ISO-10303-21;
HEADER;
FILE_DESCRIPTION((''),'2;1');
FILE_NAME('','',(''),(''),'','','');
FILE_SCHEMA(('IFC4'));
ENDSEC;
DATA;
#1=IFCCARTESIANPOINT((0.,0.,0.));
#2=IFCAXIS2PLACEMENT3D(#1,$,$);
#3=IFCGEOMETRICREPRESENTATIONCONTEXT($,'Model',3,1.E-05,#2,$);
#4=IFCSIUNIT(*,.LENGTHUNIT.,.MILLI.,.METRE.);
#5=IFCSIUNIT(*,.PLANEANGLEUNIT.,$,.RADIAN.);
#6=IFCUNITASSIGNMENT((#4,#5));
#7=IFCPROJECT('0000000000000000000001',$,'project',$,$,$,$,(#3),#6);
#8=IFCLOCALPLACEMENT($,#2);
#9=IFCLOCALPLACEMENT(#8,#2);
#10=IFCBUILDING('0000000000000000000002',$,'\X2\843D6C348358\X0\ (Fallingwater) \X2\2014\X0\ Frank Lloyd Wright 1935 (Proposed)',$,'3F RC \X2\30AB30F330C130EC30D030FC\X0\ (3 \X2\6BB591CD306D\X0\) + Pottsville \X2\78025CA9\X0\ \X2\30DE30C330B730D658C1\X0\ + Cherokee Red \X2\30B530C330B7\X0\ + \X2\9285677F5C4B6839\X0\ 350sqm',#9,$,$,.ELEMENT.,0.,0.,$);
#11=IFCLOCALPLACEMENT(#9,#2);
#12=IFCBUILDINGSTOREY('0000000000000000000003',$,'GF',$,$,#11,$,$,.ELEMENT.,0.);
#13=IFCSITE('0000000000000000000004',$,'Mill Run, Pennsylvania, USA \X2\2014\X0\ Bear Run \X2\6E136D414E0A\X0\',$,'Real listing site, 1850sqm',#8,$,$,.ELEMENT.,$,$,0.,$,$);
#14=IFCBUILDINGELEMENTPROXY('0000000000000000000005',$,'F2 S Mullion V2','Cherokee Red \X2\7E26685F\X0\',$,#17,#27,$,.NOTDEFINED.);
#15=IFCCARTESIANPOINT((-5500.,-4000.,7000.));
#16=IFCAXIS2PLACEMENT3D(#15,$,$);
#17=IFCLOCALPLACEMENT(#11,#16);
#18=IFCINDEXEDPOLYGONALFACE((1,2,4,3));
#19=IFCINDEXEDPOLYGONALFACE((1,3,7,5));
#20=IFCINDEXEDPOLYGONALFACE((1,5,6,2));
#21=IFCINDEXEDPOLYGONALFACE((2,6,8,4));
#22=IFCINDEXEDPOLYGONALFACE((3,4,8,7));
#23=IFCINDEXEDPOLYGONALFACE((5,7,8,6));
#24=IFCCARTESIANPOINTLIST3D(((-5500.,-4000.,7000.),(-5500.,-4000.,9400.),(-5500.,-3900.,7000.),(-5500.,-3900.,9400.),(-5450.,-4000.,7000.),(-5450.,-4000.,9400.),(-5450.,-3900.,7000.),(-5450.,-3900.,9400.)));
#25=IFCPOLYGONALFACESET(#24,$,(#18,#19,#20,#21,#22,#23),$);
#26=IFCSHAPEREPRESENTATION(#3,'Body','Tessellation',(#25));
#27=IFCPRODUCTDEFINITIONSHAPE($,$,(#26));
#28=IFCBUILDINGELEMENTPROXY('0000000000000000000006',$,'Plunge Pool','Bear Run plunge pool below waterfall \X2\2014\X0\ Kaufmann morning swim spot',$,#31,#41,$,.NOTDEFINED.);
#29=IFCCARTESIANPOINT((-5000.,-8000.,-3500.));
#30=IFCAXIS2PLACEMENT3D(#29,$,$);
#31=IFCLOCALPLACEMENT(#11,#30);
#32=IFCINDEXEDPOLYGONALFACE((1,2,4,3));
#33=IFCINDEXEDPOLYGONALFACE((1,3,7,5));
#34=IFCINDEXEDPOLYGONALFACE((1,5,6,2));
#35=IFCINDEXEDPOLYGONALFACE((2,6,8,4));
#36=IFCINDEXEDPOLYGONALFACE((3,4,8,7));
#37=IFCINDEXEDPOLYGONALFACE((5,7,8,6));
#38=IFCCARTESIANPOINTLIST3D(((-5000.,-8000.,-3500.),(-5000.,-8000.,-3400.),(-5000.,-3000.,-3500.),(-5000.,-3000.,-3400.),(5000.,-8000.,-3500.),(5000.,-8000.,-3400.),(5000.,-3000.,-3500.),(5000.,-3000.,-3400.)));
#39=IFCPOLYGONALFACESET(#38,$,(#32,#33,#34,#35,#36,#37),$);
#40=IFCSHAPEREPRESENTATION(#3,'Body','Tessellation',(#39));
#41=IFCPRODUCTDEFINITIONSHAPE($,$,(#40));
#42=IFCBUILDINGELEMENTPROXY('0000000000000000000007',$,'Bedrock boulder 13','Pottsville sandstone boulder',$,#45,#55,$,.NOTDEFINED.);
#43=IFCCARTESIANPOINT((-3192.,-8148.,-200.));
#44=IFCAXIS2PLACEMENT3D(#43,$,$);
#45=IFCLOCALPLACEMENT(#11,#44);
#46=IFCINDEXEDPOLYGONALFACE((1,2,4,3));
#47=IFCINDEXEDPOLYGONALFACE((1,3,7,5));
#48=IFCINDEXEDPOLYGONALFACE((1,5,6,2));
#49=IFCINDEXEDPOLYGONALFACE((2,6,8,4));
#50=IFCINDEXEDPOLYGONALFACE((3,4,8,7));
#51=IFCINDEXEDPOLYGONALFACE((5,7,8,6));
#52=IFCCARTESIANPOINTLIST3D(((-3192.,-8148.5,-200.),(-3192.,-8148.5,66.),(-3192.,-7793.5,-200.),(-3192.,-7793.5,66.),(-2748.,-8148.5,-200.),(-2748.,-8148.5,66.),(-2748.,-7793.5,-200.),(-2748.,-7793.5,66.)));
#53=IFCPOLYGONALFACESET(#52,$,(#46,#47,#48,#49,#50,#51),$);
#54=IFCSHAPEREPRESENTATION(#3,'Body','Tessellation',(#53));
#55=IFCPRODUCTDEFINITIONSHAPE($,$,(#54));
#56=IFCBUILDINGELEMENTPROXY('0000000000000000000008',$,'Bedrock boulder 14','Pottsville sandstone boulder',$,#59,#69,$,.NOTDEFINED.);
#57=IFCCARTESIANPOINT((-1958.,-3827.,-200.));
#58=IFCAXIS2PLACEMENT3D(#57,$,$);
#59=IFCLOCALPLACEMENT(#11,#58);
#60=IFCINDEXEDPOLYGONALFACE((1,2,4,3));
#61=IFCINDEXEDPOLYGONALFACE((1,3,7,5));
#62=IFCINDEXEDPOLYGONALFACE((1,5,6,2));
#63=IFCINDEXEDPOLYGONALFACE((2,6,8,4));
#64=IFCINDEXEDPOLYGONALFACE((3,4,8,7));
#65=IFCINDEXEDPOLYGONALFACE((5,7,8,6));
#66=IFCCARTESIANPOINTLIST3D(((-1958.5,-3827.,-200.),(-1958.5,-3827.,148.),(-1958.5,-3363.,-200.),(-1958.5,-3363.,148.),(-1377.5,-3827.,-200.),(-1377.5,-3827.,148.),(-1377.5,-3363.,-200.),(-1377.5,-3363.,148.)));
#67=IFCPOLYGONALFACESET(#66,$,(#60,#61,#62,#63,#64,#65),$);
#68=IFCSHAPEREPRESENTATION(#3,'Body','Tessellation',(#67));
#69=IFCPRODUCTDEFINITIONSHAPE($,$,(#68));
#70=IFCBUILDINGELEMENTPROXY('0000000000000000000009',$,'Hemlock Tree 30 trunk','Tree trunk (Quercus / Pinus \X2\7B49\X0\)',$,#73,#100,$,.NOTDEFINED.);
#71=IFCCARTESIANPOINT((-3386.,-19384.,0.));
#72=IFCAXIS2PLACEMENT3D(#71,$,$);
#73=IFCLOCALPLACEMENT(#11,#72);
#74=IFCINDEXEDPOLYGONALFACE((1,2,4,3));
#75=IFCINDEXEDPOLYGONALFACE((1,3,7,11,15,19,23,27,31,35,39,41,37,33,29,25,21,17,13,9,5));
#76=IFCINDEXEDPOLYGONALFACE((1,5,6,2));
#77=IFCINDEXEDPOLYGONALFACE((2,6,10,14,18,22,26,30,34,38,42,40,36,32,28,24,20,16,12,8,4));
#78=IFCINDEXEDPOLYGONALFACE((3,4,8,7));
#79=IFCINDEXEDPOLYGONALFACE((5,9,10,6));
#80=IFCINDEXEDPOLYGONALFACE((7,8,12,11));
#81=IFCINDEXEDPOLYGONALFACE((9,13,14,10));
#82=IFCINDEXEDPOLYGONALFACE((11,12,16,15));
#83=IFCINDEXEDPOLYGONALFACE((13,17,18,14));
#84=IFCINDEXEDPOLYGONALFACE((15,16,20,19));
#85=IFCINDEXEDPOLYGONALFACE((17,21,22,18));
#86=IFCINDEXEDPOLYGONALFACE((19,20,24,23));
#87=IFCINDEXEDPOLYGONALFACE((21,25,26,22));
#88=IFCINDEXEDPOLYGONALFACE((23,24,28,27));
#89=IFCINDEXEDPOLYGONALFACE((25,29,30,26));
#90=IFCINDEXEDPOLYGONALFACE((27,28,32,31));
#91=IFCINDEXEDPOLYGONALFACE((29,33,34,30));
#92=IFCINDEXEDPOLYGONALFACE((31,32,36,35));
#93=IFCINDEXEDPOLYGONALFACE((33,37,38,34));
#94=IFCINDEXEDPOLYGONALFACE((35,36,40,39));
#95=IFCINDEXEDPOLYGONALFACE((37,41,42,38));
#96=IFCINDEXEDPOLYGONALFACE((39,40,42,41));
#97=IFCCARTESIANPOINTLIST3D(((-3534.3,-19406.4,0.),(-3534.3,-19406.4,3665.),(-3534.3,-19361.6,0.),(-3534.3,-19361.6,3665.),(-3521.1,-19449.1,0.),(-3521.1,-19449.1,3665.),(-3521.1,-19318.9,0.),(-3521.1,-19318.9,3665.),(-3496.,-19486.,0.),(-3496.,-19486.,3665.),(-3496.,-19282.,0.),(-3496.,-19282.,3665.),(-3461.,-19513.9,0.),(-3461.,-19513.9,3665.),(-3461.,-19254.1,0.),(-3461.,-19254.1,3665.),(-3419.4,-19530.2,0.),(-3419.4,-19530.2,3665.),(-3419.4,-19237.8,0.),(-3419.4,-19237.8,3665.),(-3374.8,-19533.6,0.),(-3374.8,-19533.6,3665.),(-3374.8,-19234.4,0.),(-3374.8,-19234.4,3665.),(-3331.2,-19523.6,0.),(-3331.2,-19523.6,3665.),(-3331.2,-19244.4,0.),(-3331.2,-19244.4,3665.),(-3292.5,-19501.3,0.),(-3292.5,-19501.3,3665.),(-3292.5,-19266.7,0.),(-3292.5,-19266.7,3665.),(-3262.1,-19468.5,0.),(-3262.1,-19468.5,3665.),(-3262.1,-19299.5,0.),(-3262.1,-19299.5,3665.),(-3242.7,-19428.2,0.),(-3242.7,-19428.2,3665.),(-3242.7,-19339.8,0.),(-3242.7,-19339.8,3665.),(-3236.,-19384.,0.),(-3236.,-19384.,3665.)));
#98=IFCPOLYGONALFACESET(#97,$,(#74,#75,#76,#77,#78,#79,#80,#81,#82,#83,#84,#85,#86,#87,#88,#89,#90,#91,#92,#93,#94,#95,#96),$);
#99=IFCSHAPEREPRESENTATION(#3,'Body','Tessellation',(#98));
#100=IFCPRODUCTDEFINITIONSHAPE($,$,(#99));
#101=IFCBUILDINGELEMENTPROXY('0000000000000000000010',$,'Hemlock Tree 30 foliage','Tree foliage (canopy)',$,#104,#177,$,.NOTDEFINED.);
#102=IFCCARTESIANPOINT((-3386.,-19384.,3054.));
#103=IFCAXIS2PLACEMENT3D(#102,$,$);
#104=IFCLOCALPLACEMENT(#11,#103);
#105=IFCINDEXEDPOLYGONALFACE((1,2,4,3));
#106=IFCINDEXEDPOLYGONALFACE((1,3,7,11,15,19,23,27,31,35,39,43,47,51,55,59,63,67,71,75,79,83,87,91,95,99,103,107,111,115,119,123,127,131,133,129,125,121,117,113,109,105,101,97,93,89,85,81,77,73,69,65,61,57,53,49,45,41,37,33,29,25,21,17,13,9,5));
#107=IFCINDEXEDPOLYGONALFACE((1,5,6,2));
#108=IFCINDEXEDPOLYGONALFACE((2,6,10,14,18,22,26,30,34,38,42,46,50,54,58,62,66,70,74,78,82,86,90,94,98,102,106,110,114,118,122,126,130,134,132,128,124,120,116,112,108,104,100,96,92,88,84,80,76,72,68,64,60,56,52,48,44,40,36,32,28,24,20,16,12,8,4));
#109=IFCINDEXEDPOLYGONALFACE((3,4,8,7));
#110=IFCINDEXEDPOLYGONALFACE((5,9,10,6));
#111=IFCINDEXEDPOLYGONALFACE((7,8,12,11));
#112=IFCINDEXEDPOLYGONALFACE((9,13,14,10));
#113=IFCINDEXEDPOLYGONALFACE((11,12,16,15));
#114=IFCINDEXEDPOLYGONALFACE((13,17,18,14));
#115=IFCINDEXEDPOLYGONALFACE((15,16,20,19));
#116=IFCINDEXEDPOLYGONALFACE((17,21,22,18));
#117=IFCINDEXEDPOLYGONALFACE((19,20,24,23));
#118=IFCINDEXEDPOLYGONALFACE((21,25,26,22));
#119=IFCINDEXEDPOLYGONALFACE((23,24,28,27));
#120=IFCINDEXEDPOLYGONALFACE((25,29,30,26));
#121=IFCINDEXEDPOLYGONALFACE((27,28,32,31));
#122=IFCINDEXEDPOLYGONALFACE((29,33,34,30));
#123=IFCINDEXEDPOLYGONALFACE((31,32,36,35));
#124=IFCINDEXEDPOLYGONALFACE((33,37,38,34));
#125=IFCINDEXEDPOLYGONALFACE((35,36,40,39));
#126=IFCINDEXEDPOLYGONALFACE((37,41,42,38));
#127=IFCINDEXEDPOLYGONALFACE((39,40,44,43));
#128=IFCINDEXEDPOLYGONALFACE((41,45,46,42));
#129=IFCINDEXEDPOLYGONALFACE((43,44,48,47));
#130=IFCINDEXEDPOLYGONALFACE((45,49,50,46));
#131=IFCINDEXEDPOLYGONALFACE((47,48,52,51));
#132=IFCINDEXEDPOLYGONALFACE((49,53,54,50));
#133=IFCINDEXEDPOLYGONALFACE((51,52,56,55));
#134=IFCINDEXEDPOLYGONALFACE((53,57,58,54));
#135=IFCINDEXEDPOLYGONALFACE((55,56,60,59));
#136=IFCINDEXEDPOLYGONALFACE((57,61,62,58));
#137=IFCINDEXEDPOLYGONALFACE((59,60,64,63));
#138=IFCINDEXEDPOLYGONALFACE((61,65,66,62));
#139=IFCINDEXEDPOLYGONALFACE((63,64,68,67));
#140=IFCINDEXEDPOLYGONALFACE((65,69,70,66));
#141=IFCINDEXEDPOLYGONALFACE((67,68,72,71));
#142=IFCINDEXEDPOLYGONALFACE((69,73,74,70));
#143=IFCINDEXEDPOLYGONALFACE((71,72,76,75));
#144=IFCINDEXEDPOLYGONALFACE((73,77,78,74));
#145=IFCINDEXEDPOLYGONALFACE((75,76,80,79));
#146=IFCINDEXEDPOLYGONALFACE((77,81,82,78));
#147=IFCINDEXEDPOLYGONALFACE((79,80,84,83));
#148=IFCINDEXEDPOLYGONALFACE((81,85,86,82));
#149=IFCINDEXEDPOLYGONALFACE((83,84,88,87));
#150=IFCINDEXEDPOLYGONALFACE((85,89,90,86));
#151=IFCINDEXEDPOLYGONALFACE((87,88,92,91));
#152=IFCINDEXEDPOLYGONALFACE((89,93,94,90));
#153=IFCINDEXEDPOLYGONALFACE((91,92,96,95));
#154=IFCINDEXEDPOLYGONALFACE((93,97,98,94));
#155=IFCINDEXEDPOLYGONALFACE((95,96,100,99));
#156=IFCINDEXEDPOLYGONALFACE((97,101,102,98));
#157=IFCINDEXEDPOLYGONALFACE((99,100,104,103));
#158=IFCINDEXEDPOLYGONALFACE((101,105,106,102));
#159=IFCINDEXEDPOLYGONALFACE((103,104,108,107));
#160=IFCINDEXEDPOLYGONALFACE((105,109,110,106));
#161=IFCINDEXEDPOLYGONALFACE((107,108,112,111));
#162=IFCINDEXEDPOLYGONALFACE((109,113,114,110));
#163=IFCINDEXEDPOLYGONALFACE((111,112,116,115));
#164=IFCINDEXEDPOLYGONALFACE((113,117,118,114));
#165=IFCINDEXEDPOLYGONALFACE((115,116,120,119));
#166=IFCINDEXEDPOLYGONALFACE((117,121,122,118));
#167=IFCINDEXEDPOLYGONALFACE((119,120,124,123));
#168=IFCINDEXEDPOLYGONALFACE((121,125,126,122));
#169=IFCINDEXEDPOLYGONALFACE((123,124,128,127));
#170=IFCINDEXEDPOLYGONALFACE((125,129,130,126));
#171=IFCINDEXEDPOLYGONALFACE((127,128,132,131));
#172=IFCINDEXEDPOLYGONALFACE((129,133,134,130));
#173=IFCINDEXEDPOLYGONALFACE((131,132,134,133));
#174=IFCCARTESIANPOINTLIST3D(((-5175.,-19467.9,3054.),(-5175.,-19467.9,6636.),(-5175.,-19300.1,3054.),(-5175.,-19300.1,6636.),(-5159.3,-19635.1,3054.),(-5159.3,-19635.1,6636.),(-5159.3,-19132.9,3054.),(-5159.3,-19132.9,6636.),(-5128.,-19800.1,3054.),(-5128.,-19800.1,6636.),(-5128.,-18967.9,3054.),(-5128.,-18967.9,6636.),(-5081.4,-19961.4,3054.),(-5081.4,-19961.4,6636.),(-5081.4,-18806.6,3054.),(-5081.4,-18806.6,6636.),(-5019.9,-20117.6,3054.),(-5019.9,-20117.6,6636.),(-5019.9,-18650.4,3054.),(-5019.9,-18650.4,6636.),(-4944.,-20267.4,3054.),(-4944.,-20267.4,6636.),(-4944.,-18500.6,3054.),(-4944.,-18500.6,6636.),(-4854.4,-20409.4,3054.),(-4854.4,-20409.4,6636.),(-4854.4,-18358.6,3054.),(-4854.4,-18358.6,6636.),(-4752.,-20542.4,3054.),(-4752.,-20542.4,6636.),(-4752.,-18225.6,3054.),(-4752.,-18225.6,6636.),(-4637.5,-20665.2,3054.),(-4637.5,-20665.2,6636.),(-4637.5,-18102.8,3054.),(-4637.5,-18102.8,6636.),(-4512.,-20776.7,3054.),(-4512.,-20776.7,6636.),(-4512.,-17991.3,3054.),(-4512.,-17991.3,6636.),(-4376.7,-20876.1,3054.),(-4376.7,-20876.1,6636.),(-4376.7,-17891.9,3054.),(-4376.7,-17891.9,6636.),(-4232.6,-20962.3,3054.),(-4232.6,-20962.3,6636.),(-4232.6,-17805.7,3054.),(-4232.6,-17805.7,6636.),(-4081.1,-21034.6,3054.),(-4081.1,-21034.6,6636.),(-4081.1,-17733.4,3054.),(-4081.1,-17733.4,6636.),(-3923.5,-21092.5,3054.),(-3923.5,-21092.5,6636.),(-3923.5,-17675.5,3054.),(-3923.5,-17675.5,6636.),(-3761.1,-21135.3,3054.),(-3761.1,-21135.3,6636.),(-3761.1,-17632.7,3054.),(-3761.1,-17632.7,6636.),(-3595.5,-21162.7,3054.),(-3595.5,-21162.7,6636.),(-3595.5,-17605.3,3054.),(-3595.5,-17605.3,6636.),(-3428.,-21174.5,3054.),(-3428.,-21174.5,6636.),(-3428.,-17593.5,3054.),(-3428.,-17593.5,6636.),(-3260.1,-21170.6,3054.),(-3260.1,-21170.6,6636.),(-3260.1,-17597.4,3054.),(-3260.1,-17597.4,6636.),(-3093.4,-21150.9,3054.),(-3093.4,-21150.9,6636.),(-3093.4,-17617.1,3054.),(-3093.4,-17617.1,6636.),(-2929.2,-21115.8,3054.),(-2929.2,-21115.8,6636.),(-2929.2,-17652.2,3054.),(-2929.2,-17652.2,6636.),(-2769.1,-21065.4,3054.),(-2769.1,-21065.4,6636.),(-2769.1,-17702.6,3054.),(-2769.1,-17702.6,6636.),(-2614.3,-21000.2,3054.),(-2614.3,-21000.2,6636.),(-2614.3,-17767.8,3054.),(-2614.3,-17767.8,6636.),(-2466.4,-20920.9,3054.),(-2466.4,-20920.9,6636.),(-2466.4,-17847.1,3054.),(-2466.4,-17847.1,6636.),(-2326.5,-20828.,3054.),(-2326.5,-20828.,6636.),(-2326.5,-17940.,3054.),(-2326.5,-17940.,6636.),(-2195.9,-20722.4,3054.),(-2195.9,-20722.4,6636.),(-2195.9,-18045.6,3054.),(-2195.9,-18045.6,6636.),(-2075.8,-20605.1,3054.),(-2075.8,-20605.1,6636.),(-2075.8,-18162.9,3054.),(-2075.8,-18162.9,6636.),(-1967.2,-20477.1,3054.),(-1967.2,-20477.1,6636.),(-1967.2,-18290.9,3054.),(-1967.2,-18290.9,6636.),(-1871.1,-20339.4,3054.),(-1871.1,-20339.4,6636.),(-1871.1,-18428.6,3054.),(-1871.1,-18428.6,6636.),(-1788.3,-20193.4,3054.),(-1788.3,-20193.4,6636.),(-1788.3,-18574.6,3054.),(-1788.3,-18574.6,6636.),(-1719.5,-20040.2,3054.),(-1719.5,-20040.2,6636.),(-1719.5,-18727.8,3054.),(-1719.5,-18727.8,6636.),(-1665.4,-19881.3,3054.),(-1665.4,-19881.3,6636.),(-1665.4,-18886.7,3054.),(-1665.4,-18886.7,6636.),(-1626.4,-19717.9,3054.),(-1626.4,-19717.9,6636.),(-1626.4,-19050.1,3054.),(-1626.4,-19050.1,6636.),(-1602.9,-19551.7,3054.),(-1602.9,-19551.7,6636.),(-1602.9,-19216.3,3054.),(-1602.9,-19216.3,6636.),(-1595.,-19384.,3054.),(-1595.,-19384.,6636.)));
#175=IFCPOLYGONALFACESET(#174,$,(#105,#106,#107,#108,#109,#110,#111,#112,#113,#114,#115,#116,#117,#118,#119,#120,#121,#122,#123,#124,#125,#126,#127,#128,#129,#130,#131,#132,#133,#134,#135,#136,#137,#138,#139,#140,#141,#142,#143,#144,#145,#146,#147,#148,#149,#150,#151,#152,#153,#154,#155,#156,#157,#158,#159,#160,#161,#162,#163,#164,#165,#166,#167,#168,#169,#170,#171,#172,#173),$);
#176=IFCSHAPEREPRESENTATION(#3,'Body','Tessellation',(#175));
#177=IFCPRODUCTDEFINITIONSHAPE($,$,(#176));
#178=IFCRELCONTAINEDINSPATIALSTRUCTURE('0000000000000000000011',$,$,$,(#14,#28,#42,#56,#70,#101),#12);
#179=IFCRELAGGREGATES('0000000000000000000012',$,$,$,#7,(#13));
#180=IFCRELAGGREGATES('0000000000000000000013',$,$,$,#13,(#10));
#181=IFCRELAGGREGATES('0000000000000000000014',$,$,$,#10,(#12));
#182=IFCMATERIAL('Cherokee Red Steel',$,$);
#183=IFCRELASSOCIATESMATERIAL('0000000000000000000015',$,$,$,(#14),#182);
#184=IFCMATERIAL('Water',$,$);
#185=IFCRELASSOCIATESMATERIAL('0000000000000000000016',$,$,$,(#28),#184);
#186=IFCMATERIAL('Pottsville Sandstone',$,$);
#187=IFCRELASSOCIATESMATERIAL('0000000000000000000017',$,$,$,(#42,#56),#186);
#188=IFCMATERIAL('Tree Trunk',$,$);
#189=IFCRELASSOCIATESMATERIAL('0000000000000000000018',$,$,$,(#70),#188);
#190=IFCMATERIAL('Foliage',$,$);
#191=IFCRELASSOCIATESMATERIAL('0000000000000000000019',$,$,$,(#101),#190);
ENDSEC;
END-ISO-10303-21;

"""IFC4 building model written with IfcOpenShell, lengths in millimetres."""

from ifc_helpers import new_model, si_unit, frame, frame_2d, origin, origin_2d, place, context, project, spatial, rectangle, circle, extrude, material, element, save


model = new_model("IFC4")

# Units and contexts
model_context = context("Model", 3, precision=1e-05, world=origin())
ifc_project = project(units=[si_unit("LENGTHUNIT", "METRE", prefix="MILLI"), si_unit("PLANEANGLEUNIT", "RADIAN")], contexts=[model_context])

# Site, building, storey
site_placement = place(None, origin())
site = spatial("IfcSite", under=ifc_project, at=site_placement, Name="Mill Run, Pennsylvania, USA — Bear Run 渓流上", ObjectType="Real listing site, 1850sqm", CompositionType="ELEMENT", RefElevation=0.0)
building_placement = place(site_placement, origin())
building = spatial("IfcBuilding", under=site, at=building_placement, Name="落水荘 (Fallingwater) — Frank Lloyd Wright 1935 (Proposed)", ObjectType="3F RC カンチレバー (3 段重ね) + Pottsville 砂岩 マッシブ壁 + Cherokee Red サッシ + 銅板屋根 350sqm", CompositionType="ELEMENT", ElevationOfRefHeight=0.0, ElevationOfTerrain=0.0)
storey_placement = place(building_placement, origin())
storey = spatial("IfcBuildingStorey", under=building, at=storey_placement, Name="GF", CompositionType="ELEMENT", Elevation=0.0)

# Shared definitions
ifc_material_1 = material(Name="Cherokee Red Steel")

# Building element proxies
ifc_material_2 = material(Name="Pottsville Sandstone")
proxy_1_placement = place(storey_placement, frame((-5500.0, -4000.0, 7000.0)))
element("IfcBuildingElementProxy", 1, at=proxy_1_placement, inside=storey, material=ifc_material_1, Name="F2 S Mullion V2", Description="Cherokee Red 縦桟", PredefinedType="NOTDEFINED", context=model_context, shape_type="SweptSolid", body=[
    extrude(rectangle(XDim=50.0, YDim=100.0, at=frame_2d((25.0, 50.0))), frame((-5500.0, -4000.0, 7000.0)), (0.0, 0.0, 1.0), 2400.0),
])
ifc_material_3 = material(Name="Water")
proxy_2_placement = place(storey_placement, frame((-5000.0, -8000.0, -3500.0)))
element("IfcBuildingElementProxy", 2, at=proxy_2_placement, inside=storey, material=ifc_material_3, Name="Plunge Pool", Description="Bear Run plunge pool below waterfall — Kaufmann morning swim spot", PredefinedType="NOTDEFINED", context=model_context, shape_type="SweptSolid", body=[
    extrude(rectangle(XDim=10000.0, YDim=5000.0, at=frame_2d((5000.0, 2500.0))), frame((-5000.0, -8000.0, -3500.0)), (0.0, 0.0, 1.0), 100.0),
])
proxy_3_placement = place(storey_placement, frame((-3192.0, -8148.0, -200.0)))
element("IfcBuildingElementProxy", 3, at=proxy_3_placement, inside=storey, material=ifc_material_2, Name="Bedrock boulder 13", Description="Pottsville sandstone boulder", PredefinedType="NOTDEFINED", context=model_context, shape_type="SweptSolid", body=[
    extrude(rectangle(XDim=444.0, YDim=355.0, at=frame_2d((222.0, 177.0))), frame((-3192.0, -8148.0, -200.0)), (0.0, 0.0, 1.0), 266.0),
])
proxy_4_placement = place(storey_placement, frame((-1958.0, -3827.0, -200.0)))
element("IfcBuildingElementProxy", 4, at=proxy_4_placement, inside=storey, material=ifc_material_2, Name="Bedrock boulder 14", Description="Pottsville sandstone boulder", PredefinedType="NOTDEFINED", context=model_context, shape_type="SweptSolid", body=[
    extrude(rectangle(XDim=581.0, YDim=464.0, at=frame_2d((290.0, 232.0))), frame((-1958.0, -3827.0, -200.0)), (0.0, 0.0, 1.0), 348.0),
])
ifc_material_4 = material(Name="Tree Trunk")
proxy_5_placement = place(storey_placement, frame((-3386.0, -19384.0, 0.0)))
element("IfcBuildingElementProxy", 5, at=proxy_5_placement, inside=storey, material=ifc_material_4, Name="Hemlock Tree 30 trunk", Description="Tree trunk (Quercus / Pinus 等)", PredefinedType="NOTDEFINED", context=model_context, shape_type="SweptSolid", body=[
    extrude(circle(Radius=150.0, at=origin_2d()), frame((-3386.0, -19384.0, 0.0)), (0.0, 0.0, 1.0), 3665.0),
])
ifc_material_5 = material(Name="Foliage")
proxy_6_placement = place(storey_placement, frame((-3386.0, -19384.0, 3054.0)))
element("IfcBuildingElementProxy", 6, at=proxy_6_placement, inside=storey, material=ifc_material_5, Name="Hemlock Tree 30 foliage", Description="Tree foliage (canopy)", PredefinedType="NOTDEFINED", context=model_context, shape_type="SweptSolid", body=[
    extrude(circle(Radius=1791.0, at=origin_2d()), frame((-3386.0, -19384.0, 3054.0)), (0.0, 0.0, 1.0), 3582.0),
])

save(model, "model.ifc")
